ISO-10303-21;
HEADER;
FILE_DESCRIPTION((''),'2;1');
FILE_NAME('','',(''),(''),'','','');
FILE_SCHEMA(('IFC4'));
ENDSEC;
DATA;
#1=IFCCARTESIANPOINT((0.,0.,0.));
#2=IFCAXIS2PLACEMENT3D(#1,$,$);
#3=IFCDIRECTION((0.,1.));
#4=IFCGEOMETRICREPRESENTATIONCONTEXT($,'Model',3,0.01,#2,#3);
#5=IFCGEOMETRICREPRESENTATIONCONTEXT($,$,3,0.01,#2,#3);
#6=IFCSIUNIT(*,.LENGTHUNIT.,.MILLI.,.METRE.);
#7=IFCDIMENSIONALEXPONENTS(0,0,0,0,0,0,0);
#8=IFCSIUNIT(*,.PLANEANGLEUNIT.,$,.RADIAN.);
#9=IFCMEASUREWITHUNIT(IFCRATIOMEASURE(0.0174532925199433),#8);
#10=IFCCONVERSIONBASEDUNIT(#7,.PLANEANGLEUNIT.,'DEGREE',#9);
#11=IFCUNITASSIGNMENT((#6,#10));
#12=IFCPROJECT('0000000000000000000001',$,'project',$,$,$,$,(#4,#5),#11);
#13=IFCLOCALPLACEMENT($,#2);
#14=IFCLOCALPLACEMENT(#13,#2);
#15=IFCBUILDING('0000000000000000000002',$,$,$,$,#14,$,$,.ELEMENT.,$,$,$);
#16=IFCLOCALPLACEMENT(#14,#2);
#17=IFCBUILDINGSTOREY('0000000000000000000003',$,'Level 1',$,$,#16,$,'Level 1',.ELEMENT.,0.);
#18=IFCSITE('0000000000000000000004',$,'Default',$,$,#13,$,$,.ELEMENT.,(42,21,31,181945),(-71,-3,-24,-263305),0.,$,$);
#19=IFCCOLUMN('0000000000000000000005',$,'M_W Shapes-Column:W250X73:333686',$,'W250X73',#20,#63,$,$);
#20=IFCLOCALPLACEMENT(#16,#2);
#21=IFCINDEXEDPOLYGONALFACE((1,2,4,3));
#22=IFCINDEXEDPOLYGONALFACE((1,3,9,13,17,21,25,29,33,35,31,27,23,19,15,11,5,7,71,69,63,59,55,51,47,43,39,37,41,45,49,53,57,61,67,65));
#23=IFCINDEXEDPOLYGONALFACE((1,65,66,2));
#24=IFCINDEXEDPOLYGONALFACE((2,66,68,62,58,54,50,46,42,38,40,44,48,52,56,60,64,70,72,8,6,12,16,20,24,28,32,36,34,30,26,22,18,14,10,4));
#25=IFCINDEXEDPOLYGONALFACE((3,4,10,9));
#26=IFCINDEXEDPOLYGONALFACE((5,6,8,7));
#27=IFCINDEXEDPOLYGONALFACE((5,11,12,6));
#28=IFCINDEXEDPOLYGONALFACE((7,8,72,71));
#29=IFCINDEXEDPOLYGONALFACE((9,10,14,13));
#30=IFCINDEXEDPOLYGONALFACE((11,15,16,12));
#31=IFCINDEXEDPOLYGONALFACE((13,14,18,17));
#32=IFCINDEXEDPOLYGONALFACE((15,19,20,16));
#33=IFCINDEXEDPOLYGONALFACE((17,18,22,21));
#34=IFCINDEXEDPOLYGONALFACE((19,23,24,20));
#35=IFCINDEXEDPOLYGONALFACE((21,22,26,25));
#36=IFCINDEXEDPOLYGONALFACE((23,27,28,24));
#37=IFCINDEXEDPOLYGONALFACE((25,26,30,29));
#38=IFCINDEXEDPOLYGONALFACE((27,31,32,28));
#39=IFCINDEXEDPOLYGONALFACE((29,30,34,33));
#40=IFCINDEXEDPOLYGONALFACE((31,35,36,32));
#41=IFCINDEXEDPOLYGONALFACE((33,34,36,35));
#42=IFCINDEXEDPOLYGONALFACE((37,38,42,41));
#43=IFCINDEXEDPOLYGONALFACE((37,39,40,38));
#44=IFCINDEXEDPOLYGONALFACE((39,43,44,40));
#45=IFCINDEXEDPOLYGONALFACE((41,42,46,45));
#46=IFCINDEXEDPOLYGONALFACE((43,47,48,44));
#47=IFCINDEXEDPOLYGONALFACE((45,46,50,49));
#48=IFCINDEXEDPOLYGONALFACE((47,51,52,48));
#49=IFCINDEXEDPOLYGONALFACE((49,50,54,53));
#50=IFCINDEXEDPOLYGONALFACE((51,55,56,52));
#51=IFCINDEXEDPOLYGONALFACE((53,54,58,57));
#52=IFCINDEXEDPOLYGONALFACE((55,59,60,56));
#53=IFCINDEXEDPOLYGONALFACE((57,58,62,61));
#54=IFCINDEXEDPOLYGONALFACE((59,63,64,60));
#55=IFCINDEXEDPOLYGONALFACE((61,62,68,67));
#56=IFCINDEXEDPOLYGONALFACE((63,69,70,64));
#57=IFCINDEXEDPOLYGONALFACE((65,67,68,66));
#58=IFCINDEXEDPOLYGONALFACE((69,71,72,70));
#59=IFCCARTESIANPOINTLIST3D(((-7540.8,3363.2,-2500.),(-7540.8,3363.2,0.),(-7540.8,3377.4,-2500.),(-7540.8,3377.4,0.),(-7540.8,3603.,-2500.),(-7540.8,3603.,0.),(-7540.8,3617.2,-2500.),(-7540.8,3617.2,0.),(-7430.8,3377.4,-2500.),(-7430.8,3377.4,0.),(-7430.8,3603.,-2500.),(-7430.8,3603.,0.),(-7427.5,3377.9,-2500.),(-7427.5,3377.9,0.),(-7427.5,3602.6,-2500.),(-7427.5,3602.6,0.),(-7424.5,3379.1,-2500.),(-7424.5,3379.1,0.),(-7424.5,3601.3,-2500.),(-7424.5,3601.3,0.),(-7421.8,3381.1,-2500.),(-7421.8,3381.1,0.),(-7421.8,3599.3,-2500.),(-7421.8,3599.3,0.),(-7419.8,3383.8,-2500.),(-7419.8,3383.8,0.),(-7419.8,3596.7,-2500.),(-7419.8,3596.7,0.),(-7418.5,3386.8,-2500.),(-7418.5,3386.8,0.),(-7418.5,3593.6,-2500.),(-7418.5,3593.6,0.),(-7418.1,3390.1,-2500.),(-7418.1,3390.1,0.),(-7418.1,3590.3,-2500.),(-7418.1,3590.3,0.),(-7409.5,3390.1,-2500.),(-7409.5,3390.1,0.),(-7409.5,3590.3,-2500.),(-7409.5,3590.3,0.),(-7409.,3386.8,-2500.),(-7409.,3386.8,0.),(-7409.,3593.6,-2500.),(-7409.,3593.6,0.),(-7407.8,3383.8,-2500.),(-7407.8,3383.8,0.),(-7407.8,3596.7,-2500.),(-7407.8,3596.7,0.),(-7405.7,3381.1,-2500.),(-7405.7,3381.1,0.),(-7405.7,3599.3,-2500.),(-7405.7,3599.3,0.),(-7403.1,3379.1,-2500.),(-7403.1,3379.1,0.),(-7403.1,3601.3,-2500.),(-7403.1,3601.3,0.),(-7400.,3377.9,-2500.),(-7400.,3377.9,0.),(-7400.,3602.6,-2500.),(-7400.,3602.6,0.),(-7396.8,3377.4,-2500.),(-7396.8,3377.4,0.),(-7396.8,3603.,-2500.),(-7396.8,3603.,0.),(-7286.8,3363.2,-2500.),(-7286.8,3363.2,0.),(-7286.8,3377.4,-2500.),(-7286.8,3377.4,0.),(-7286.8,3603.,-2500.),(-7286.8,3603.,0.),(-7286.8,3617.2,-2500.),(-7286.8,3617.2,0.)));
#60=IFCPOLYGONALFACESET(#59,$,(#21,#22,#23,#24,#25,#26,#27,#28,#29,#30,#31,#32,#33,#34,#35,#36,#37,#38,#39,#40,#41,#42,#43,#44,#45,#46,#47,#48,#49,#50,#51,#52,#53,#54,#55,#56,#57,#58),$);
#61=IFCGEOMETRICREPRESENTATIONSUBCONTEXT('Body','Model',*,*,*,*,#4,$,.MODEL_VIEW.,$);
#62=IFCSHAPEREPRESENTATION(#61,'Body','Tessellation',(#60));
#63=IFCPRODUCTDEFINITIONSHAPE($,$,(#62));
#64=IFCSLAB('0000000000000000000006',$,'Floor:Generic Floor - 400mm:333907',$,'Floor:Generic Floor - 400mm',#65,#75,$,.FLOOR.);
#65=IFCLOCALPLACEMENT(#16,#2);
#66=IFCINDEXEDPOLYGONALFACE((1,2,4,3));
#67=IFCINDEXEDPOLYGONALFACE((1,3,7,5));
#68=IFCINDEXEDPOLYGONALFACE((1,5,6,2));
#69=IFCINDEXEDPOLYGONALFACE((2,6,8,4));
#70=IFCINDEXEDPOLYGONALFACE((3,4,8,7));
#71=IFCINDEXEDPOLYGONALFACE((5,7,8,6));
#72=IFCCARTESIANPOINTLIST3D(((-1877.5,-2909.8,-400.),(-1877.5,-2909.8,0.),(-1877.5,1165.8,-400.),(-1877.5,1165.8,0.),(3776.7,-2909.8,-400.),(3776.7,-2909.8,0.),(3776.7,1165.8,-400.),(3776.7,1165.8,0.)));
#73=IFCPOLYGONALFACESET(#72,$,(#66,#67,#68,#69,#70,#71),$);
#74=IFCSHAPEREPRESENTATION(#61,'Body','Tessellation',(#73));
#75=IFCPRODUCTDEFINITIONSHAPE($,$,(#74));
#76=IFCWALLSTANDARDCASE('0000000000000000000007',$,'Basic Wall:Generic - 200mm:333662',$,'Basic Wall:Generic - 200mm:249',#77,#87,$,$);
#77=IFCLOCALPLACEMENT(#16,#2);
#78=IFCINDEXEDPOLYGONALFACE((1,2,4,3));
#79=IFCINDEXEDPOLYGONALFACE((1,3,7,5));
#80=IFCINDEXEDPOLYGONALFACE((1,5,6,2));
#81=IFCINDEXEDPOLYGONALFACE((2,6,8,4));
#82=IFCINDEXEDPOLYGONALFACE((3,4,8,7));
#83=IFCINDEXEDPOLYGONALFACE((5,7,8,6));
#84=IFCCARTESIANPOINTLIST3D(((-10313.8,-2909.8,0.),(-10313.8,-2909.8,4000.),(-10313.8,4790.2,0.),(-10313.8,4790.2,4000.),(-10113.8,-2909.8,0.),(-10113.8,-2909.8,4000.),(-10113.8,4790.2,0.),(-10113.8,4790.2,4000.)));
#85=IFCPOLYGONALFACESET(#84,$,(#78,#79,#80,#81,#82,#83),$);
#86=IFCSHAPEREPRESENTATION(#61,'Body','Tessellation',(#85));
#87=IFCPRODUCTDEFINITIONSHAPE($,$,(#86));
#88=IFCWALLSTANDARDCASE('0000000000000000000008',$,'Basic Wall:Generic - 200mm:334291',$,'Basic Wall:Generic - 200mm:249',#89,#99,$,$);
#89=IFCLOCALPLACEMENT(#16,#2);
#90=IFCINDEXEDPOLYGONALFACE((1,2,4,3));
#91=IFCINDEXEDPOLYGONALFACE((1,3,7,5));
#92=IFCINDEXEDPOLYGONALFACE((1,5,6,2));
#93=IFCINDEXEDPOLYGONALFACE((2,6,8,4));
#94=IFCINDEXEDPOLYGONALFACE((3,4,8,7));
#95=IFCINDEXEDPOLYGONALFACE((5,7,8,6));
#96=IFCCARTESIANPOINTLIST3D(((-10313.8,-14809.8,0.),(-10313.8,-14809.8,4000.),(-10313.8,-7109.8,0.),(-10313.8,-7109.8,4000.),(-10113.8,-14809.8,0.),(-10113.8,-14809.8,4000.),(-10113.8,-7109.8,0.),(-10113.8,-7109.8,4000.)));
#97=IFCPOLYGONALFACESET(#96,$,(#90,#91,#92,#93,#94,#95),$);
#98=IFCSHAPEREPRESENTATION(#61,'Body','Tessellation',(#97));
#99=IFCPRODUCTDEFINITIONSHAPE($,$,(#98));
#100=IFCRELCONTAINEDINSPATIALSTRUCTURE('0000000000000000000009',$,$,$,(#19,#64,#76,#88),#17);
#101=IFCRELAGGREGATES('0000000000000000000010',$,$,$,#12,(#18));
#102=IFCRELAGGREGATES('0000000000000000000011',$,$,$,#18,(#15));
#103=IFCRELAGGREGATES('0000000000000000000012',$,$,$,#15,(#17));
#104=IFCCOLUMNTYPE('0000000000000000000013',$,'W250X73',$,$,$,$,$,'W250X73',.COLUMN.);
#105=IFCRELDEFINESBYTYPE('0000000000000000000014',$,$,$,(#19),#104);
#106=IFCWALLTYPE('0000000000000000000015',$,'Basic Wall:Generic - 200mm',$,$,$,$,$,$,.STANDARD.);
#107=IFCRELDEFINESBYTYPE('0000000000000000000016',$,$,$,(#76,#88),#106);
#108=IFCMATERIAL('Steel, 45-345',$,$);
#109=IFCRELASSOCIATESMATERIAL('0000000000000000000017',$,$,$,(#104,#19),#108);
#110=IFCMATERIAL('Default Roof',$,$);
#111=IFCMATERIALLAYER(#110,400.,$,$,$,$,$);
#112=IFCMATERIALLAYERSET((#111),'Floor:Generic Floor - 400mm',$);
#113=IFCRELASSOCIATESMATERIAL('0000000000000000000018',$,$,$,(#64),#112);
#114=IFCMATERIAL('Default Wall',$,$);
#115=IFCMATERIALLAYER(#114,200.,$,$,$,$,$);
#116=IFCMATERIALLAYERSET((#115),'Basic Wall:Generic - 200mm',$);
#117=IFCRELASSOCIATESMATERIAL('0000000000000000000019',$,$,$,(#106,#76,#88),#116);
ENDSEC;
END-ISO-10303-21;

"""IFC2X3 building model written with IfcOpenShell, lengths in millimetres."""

from ifc_helpers import new_model, entity, si_unit, converted_unit, direction, frame, frame_2d, origin, origin_2d_with_axis, place, context, subcontext, project, spatial, rectangle, i_section, extrude, clip, halfspace, source, transform, mapped, material, layer, layer_set, layer_usage, type_object, type_shapes, element, save


model = new_model("IFC2X3")

# Units and contexts
model_context = context("Model", 3, precision=0.01, world=origin(), true_north=direction((0.0, 1.0)))
context_of_model = context(None, 3, precision=0.01, world=origin(), true_north=direction((0.0, 1.0)))
body_context = subcontext(model_context, "Body", "Model", "MODEL_VIEW")
ifc_project = project(units=[si_unit("LENGTHUNIT", "METRE", prefix="MILLI"), converted_unit("PLANEANGLEUNIT", "DEGREE", entity("IfcRatioMeasure", 0.0174532925199433), si_unit("PLANEANGLEUNIT", "RADIAN"), dimensions=[0, 0, 0, 0, 0, 0, 0])], contexts=[model_context, context_of_model])

# Site, building, storey
site_placement = place(None, origin())
site = spatial("IfcSite", under=ifc_project, at=site_placement, Name="Default", CompositionType="ELEMENT", RefLatitude=(42, 21, 31, 181945), RefLongitude=(-71, -3, -24, -263305), RefElevation=0.0)
building_placement = place(site_placement, origin())
building = spatial("IfcBuilding", under=site, at=building_placement, CompositionType="ELEMENT")
storey_placement = place(building_placement, origin())
storey = spatial("IfcBuildingStorey", under=building, at=storey_placement, Name="Level 1", LongName="Level 1", CompositionType="ELEMENT", Elevation=0.0)

# Column
ifc_material_1 = material(Name="Steel, 45-345")
column_type = type_object("IfcColumnType", Name="W250X73", ElementType="W250X73", PredefinedType="COLUMN", material=ifc_material_1)
shared_shape = source(origin(), body_context, "Body", "SweptSolid", [
    extrude(i_section(OverallWidth=254.0, OverallDepth=254.0, WebThickness=8.6, FlangeThickness=14.2, FilletRadius=12.7, at=frame_2d((0.0, 0.0), x_axis=(1.0, 0.0))), frame((0.0, 0.0, -2500.0), z_axis=(0.0, 0.0, 1.0), x_axis=(-1.0, 0.0, 0.0)), (0.0, 0.0, 1.0), 2500.0),
])
type_shapes(column_type, [shared_shape])
column_placement = place(storey_placement, frame((-7413.8, 3490.2, 0.0)))
element("IfcColumn", 1, at=column_placement, inside=storey, type_object=column_type, material=ifc_material_1, Name="M_W Shapes-Column:W250X73:333686", ObjectType="W250X73", context=body_context, shape_type="MappedRepresentation", body=[
    mapped(shared_shape, transform((0.0, 0.0, 0.0), scale=1.0)),
])

# Slab
ifc_material_2 = material(Name="Default Roof")
ifc_layer_1 = layer(ifc_material_2, 400.0)
ifc_layer_set_1 = layer_set([ifc_layer_1], Name="Floor:Generic Floor - 400mm")
ifc_layer_usage_1 = layer_usage(ifc_layer_set_1, "AXIS3", "POSITIVE", 0.0)
slab_placement = place(storey_placement, origin())
element("IfcSlab", 2, at=slab_placement, inside=storey, material=ifc_layer_usage_1, Name="Floor:Generic Floor - 400mm:333907", ObjectType="Floor:Generic Floor - 400mm", PredefinedType="FLOOR", context=body_context, shape_type="SweptSolid", body=[
    extrude(rectangle(XDim=4075.5, YDim=5654.2, at=origin_2d_with_axis()), frame((949.6, -872.0, 0.0), z_axis=(0.0, 0.0, -1.0), x_axis=(0.0, 1.0, 0.0)), (0.0, 0.0, 1.0), 400.0),
])

# Walls
ifc_material_3 = material(Name="Default Wall")
ifc_layer_2 = layer(ifc_material_3, 200.0)
ifc_layer_set_2 = layer_set([ifc_layer_2], Name="Basic Wall:Generic - 200mm")
ifc_layer_usage_2 = layer_usage(ifc_layer_set_2, "AXIS2", "NEGATIVE", 100.0)
wall_type = type_object("IfcWallType", Name="Basic Wall:Generic - 200mm", PredefinedType="STANDARD", material=ifc_layer_set_2)
wall_1_placement = place(storey_placement, frame((-10213.8, 4790.2, 0.0), z_axis=(0.0, 0.0, 1.0), x_axis=(0.0, -1.0, 0.0)))
element("IfcWallStandardCase", 3, at=wall_1_placement, inside=storey, type_object=wall_type, material=ifc_layer_usage_2, Name="Basic Wall:Generic - 200mm:333662", ObjectType="Basic Wall:Generic - 200mm:249", context=body_context, shape_type="Clipping", body=[
    clip(extrude(rectangle(XDim=7700.0, YDim=200.0, at=frame_2d((3850.0, 0.0), x_axis=(-1.0, 0.0))), origin(), (0.0, 0.0, 1.0), 4000.0), halfspace(origin(), True)),
])
ifc_layer_usage_3 = layer_usage(ifc_layer_set_2, "AXIS2", "NEGATIVE", 100.0)
wall_2_placement = place(storey_placement, frame((-10213.8, -7109.8, 0.0), z_axis=(0.0, 0.0, 1.0), x_axis=(0.0, -1.0, 0.0)))
element("IfcWallStandardCase", 4, at=wall_2_placement, inside=storey, type_object=wall_type, material=ifc_layer_usage_3, Name="Basic Wall:Generic - 200mm:334291", ObjectType="Basic Wall:Generic - 200mm:249", context=body_context, shape_type="Clipping", body=[
    clip(extrude(rectangle(XDim=7700.0, YDim=200.0, at=frame_2d((3850.0, 0.0), x_axis=(-1.0, 0.0))), origin(), (0.0, 0.0, 1.0), 4000.0), halfspace(origin(), True)),
])

save(model, "model.ifc")
